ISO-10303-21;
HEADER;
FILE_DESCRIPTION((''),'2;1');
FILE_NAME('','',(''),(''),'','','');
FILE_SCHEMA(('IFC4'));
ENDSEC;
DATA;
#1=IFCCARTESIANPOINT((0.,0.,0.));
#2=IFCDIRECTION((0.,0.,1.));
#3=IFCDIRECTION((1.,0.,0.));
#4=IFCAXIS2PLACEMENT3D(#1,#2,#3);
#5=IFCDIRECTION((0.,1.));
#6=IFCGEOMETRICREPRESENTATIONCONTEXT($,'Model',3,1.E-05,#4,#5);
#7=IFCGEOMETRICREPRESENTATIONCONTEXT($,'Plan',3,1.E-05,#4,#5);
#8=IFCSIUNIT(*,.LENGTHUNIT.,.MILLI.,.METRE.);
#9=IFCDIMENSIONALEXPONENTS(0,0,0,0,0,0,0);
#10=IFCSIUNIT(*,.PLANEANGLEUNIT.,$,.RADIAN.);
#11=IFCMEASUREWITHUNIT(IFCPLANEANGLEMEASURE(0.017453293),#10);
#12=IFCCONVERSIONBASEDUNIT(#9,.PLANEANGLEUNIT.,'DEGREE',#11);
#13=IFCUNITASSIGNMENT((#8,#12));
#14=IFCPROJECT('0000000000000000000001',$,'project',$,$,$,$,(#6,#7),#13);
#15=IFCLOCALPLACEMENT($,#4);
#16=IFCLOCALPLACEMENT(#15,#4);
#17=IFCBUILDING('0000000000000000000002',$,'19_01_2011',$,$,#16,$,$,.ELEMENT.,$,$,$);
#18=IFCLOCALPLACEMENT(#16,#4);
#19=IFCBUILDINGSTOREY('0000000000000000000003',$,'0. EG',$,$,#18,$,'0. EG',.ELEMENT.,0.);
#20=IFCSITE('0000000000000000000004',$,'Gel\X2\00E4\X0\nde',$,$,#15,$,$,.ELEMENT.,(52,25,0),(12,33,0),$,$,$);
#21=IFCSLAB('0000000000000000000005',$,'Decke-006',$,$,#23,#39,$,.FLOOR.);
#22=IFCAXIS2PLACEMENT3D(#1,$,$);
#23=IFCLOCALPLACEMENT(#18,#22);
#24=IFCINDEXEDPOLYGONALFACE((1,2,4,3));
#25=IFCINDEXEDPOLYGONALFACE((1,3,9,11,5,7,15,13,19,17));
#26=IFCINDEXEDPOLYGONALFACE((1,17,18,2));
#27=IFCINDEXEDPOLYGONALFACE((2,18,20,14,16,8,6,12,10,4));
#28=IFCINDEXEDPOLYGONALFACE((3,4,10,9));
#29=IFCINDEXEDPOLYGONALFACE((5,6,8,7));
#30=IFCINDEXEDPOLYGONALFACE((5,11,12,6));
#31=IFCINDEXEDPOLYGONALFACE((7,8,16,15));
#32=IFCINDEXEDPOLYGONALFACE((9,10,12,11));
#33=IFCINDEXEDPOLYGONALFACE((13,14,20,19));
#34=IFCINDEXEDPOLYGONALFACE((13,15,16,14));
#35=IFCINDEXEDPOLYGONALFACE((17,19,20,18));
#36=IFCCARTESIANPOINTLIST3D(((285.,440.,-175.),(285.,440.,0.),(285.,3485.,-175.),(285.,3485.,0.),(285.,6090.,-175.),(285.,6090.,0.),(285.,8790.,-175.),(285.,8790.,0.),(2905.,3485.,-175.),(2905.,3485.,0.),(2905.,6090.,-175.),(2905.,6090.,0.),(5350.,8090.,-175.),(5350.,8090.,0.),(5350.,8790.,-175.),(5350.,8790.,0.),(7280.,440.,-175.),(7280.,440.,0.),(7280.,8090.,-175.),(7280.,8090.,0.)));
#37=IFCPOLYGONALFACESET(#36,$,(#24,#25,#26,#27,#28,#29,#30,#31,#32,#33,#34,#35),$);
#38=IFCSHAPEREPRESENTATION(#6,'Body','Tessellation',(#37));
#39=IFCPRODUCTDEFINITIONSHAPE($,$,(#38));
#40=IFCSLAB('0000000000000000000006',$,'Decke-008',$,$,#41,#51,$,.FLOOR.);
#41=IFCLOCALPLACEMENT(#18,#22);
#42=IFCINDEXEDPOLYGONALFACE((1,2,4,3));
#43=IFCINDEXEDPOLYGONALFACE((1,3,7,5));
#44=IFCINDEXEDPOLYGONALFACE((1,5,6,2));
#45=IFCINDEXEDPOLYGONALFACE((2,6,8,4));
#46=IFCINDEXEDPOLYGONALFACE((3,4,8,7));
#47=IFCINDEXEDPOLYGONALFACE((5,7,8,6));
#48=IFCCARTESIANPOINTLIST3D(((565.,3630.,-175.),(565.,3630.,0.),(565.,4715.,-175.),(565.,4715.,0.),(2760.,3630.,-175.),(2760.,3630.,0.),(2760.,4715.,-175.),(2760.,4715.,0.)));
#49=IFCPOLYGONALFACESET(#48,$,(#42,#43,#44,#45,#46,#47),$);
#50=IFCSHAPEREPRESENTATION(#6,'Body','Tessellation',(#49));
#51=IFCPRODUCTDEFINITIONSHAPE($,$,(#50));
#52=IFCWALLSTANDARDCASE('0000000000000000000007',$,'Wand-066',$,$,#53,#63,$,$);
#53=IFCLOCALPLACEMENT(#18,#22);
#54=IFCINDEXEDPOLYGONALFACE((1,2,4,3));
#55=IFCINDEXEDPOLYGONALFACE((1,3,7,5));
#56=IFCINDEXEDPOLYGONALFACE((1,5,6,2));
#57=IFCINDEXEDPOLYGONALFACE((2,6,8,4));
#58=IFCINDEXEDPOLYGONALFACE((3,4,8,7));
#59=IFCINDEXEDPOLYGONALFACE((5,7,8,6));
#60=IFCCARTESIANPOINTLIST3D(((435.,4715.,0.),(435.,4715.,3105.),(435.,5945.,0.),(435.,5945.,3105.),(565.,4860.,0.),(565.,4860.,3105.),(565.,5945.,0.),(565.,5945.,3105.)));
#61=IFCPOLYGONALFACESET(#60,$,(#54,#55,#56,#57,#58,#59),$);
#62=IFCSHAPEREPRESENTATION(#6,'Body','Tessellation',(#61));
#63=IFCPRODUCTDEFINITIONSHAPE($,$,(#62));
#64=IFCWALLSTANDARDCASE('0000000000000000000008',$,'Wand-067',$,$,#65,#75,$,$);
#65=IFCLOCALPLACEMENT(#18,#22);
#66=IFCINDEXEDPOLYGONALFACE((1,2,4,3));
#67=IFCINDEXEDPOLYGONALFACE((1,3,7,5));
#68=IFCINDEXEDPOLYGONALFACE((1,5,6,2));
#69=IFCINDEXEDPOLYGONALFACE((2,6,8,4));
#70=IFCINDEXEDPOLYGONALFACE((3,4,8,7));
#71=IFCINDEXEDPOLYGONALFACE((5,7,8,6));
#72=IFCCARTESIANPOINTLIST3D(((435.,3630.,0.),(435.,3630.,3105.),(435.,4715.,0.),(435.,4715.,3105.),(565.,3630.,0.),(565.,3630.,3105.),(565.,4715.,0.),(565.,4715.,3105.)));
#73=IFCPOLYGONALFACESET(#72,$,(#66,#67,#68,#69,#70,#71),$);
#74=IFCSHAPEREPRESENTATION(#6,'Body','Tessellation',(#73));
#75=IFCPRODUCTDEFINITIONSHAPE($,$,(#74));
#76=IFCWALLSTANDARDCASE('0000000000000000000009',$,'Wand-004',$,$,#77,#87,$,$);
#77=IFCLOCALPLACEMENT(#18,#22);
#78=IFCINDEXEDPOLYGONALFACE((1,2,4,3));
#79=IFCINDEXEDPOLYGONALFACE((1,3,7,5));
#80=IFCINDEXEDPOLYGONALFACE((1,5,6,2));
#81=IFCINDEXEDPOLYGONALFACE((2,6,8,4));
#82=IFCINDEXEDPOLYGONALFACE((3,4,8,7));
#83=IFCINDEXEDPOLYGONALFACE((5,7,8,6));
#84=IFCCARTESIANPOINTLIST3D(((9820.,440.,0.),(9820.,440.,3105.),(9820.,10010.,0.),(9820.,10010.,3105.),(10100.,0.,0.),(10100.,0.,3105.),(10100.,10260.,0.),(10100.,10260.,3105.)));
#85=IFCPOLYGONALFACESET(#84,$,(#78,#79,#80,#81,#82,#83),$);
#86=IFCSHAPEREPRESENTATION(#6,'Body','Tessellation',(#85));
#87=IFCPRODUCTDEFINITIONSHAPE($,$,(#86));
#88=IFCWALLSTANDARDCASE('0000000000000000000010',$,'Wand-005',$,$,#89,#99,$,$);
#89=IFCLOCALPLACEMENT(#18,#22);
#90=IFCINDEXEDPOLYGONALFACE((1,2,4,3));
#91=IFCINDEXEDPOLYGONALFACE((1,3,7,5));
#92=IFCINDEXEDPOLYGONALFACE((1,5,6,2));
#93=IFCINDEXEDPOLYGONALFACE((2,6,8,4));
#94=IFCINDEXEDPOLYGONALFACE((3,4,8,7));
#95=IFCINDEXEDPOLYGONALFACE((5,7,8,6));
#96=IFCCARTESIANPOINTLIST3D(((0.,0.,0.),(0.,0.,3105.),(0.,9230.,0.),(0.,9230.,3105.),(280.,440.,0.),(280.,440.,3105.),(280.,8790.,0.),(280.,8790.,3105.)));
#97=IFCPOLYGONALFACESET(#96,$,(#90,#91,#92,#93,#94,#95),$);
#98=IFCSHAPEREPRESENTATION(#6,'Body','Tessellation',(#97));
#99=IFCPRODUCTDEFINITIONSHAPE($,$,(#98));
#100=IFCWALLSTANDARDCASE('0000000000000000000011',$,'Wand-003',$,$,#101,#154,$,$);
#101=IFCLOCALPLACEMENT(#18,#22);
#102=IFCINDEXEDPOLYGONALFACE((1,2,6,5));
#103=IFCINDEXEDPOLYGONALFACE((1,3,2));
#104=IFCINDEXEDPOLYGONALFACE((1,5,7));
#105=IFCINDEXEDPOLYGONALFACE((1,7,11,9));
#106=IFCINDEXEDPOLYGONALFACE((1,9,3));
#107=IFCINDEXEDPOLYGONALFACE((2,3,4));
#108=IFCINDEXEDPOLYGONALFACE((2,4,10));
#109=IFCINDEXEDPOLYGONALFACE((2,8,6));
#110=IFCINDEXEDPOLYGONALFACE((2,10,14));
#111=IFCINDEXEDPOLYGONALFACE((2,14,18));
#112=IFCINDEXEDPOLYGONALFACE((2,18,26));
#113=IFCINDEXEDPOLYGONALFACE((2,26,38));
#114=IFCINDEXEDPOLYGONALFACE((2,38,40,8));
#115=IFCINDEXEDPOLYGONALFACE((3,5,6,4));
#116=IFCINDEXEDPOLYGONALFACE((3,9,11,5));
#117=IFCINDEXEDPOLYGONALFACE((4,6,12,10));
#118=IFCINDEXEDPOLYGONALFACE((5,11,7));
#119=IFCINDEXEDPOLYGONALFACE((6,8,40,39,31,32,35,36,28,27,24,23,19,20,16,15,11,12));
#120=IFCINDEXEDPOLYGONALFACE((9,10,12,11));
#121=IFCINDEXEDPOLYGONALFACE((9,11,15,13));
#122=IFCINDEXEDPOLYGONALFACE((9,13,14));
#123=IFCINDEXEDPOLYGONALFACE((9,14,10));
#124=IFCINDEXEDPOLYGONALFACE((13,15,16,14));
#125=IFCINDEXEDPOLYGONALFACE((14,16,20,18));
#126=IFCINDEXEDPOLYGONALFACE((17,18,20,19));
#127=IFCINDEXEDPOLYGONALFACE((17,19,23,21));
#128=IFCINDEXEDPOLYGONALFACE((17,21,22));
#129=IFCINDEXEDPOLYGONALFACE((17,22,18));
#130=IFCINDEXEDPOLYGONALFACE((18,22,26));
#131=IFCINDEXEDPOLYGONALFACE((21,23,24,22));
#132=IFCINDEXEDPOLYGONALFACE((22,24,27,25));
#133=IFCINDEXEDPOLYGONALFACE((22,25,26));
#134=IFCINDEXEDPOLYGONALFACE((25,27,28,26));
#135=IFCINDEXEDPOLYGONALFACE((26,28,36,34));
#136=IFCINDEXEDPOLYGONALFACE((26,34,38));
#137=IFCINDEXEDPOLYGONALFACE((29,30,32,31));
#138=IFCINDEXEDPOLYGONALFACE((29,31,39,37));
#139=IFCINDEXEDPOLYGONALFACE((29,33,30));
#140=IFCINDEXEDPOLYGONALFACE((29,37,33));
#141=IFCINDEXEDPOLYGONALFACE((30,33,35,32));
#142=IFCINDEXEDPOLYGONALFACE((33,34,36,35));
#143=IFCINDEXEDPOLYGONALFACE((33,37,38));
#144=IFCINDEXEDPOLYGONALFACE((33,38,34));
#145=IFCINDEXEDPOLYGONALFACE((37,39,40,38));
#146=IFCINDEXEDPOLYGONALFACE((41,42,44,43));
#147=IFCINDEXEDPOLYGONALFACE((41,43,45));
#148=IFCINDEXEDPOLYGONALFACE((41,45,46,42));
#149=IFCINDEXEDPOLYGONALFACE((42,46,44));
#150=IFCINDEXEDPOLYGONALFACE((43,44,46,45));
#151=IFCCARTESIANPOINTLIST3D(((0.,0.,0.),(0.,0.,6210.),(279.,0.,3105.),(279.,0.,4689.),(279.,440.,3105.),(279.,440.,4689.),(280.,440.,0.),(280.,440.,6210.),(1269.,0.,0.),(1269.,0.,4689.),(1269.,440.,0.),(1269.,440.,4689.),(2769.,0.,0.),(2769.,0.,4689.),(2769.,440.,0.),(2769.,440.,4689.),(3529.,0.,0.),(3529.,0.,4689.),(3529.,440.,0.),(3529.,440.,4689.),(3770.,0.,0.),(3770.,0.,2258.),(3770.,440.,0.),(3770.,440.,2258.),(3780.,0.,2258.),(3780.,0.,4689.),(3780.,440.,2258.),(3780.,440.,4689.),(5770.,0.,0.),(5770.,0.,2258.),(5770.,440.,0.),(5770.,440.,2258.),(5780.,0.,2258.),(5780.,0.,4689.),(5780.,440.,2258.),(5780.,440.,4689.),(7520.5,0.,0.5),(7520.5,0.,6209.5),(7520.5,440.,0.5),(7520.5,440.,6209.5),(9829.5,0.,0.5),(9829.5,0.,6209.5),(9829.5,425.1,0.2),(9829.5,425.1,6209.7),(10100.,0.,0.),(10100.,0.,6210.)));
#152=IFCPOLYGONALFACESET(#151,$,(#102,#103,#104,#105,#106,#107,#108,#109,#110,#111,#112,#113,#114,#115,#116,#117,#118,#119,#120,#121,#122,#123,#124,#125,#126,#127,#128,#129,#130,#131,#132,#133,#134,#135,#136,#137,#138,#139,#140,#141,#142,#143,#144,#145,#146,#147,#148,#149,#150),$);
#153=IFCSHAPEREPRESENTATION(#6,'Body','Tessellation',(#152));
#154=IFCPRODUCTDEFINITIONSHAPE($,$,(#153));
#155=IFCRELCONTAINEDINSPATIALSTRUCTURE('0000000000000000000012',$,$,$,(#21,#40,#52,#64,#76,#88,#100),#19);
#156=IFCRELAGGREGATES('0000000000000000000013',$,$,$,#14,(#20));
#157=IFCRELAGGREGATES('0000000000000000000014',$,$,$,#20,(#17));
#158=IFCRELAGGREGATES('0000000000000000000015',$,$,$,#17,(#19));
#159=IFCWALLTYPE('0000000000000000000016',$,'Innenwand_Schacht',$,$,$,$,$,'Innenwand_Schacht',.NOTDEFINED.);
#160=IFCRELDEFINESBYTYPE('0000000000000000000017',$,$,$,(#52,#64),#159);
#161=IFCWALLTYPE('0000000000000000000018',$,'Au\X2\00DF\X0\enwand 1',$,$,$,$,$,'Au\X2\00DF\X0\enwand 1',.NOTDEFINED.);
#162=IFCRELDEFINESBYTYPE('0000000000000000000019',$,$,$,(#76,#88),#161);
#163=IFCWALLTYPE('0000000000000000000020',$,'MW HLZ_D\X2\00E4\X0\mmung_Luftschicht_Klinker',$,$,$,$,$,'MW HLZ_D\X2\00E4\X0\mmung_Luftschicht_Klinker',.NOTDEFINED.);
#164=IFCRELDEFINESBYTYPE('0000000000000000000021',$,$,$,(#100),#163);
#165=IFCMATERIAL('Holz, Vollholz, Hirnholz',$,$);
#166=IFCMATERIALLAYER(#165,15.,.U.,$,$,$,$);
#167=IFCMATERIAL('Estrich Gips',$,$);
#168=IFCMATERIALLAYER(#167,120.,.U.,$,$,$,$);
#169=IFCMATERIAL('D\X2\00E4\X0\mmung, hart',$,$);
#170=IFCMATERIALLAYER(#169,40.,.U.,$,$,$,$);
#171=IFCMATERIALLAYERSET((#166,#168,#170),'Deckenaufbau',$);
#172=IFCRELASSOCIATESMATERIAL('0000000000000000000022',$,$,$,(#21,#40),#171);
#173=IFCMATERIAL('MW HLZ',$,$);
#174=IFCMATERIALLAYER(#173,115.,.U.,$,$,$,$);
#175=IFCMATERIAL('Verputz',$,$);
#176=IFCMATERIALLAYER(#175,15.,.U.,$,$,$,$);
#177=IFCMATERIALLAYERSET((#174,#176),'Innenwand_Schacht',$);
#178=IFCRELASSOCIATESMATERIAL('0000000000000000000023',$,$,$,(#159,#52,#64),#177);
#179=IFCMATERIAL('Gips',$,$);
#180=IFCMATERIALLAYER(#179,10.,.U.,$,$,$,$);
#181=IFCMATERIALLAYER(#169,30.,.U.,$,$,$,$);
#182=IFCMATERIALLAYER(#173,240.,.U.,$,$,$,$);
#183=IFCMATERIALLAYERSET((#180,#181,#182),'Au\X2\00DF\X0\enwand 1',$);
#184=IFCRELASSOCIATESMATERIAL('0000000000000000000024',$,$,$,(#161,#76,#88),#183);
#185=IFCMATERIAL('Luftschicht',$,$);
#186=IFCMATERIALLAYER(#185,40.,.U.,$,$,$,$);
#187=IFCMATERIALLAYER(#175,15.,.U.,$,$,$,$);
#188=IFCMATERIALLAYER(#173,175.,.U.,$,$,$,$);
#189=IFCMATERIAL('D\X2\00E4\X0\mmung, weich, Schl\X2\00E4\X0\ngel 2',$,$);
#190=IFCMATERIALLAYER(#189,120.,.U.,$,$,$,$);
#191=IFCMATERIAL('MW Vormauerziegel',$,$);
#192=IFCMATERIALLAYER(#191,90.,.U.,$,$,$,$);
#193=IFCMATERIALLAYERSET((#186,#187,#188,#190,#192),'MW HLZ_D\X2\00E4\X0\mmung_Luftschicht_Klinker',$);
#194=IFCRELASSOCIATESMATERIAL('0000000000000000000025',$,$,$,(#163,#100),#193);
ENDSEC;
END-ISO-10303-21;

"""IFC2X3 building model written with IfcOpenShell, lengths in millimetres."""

from ifc_helpers import new_model, entity, si_unit, converted_unit, direction, frame, frame_2d, origin_with_axes, place, context, project, spatial, polyline, rectangle, outline, extrude, material, layer, layer_set, layer_usage, type_object, element, save


model = new_model("IFC2X3")

# Units and contexts
model_context = context("Model", 3, precision=1e-05, world=origin_with_axes(), true_north=direction((0.0, 1.0)))
plan_context = context("Plan", 3, precision=1e-05, world=origin_with_axes(), true_north=direction((0.0, 1.0)))
ifc_project = project(units=[si_unit("LENGTHUNIT", "METRE", prefix="MILLI"), converted_unit("PLANEANGLEUNIT", "DEGREE", entity("IfcPlaneAngleMeasure", 0.017453293), si_unit("PLANEANGLEUNIT", "RADIAN"), dimensions=[0, 0, 0, 0, 0, 0, 0])], contexts=[model_context, plan_context])

# Site, building, storey
site_placement = place(None, origin_with_axes())
site = spatial("IfcSite", under=ifc_project, at=site_placement, Name="Gelände", CompositionType="ELEMENT", RefLatitude=(52, 25, 0), RefLongitude=(12, 33, 0))
building_placement = place(site_placement, origin_with_axes())
building = spatial("IfcBuilding", under=site, at=building_placement, Name="19_01_2011", CompositionType="ELEMENT")
storey_placement = place(building_placement, origin_with_axes())
storey = spatial("IfcBuildingStorey", under=building, at=storey_placement, Name="0. EG", LongName="0. EG", CompositionType="ELEMENT", Elevation=0.0)

# Slabs
ifc_material_1 = material(Name="Holz, Vollholz, Hirnholz")
ifc_layer_1 = layer(ifc_material_1, 15.0, ventilated="UNKNOWN")
ifc_material_2 = material(Name="Estrich Gips")
ifc_layer_2 = layer(ifc_material_2, 120.0, ventilated="UNKNOWN")
ifc_material_3 = material(Name="Dämmung, hart")
ifc_layer_3 = layer(ifc_material_3, 40.0, ventilated="UNKNOWN")
ifc_layer_set_1 = layer_set([ifc_layer_1, ifc_layer_2, ifc_layer_3], Name="Deckenaufbau")
ifc_layer_usage_1 = layer_usage(ifc_layer_set_1, "AXIS3", "NEGATIVE", 175.0)
slab_1_placement = place(storey_placement, frame((285.0, 440.0, -175.0), z_axis=(0.0, 0.0, 1.0), x_axis=(1.0, 0.0, 0.0)))
element("IfcSlab", 1, at=slab_1_placement, inside=storey, material=ifc_layer_usage_1, Name="Decke-006", PredefinedType="FLOOR", context=model_context, shape_type="SweptSolid", body=[
    extrude(outline(polyline([(0.0, 0.0), (6995.0, 0.0), (6995.0, 7650.0), (5065.0, 7650.0), (5065.0, 8350.0), (0.0, 8350.0), (0.0, 5650.0), (2620.0, 5650.0), (2620.0, 3045.0), (0.0, 3045.0), (0.0, 0.0)])), origin_with_axes(), (0.0, 0.0, 1.0), 175.0),
])
ifc_layer_usage_2 = layer_usage(ifc_layer_set_1, "AXIS3", "NEGATIVE", 175.0)
slab_2_placement = place(storey_placement, frame((565.0, 4715.0, -175.0), z_axis=(0.0, 0.0, 1.0), x_axis=(1.0, 0.0, 0.0)))
element("IfcSlab", 2, at=slab_2_placement, inside=storey, material=ifc_layer_usage_2, Name="Decke-008", PredefinedType="FLOOR", context=model_context, shape_type="SweptSolid", body=[
    extrude(outline(polyline([(0.0, 0.0), (2195.0, 0.0), (2195.0, -1085.0), (0.0, -1085.0), (0.0, 0.0)])), origin_with_axes(), (0.0, 0.0, 1.0), 175.0),
])

# Walls
ifc_material_4 = material(Name="MW HLZ")
ifc_layer_4 = layer(ifc_material_4, 115.0, ventilated="UNKNOWN")
ifc_material_5 = material(Name="Verputz")
ifc_layer_5 = layer(ifc_material_5, 15.0, ventilated="UNKNOWN")
ifc_layer_set_2 = layer_set([ifc_layer_4, ifc_layer_5], Name="Innenwand_Schacht")
ifc_layer_usage_3 = layer_usage(ifc_layer_set_2, "AXIS2", "NEGATIVE", 0.0)
wall_type_1 = type_object("IfcWallType", Name="Innenwand_Schacht", ElementType="Innenwand_Schacht", PredefinedType="NOTDEFINED", material=ifc_layer_set_2)
wall_1_placement = place(storey_placement, frame((435.0, 4715.0, 0.0), z_axis=(0.0, 0.0, 1.0), x_axis=(0.0, 1.0, 0.0)))
element("IfcWallStandardCase", 3, at=wall_1_placement, inside=storey, type_object=wall_type_1, material=ifc_layer_usage_3, Name="Wand-066", context=model_context, shape_type="SweptSolid", body=[
    extrude(outline(polyline([(145.0, -130.0), (1230.0, -130.0), (1230.0, 0.0), (0.0, 0.0), (145.0, -130.0)])), origin_with_axes(), (0.0, 0.0, 1.0), 3105.0),
])
ifc_layer_usage_4 = layer_usage(ifc_layer_set_2, "AXIS2", "POSITIVE", 0.0)
wall_2_placement = place(storey_placement, frame((435.0, 4715.0, 0.0), z_axis=(0.0, 0.0, 1.0), x_axis=(0.0, -1.0, 0.0)))
element("IfcWallStandardCase", 4, at=wall_2_placement, inside=storey, type_object=wall_type_1, material=ifc_layer_usage_4, Name="Wand-067", context=model_context, shape_type="SweptSolid", body=[
    extrude(outline(polyline([(0.0, 0.0), (1085.0, 0.0), (1085.0, 130.0), (0.0, 130.0), (0.0, 0.0)])), origin_with_axes(), (0.0, 0.0, 1.0), 3105.0),
])
ifc_material_6 = material(Name="Gips")
ifc_layer_6 = layer(ifc_material_6, 10.0, ventilated="UNKNOWN")
ifc_layer_7 = layer(ifc_material_3, 30.0, ventilated="UNKNOWN")
ifc_layer_8 = layer(ifc_material_4, 240.0, ventilated="UNKNOWN")
ifc_layer_set_3 = layer_set([ifc_layer_6, ifc_layer_7, ifc_layer_8], Name="Außenwand 1")
ifc_layer_usage_5 = layer_usage(ifc_layer_set_3, "AXIS2", "POSITIVE", 0.0)
wall_type_2 = type_object("IfcWallType", Name="Außenwand 1", ElementType="Außenwand 1", PredefinedType="NOTDEFINED", material=ifc_layer_set_3)
wall_3_placement = place(storey_placement, frame((10100.0, 0.0, 0.0), z_axis=(0.0, 0.0, 1.0), x_axis=(0.0, 1.0, 0.0)))
element("IfcWallStandardCase", 5, at=wall_3_placement, inside=storey, type_object=wall_type_2, material=ifc_layer_usage_5, Name="Wand-004", context=model_context, shape_type="SweptSolid", body=[
    extrude(outline(polyline([(0.0, 0.0), (10260.0, 0.0), (10010.0, 280.0), (440.0, 280.0), (0.0, 0.0)])), origin_with_axes(), (0.0, 0.0, 1.0), 3105.0),
])
ifc_layer_usage_6 = layer_usage(ifc_layer_set_3, "AXIS2", "NEGATIVE", 0.0)
wall_4_placement = place(storey_placement, frame((0.0, 0.0, 0.0), z_axis=(0.0, 0.0, 1.0), x_axis=(0.0, 1.0, 0.0)))
element("IfcWallStandardCase", 6, at=wall_4_placement, inside=storey, type_object=wall_type_2, material=ifc_layer_usage_6, Name="Wand-005", context=model_context, shape_type="SweptSolid", body=[
    extrude(outline(polyline([(440.0, -280.0), (8790.0, -280.0), (9230.0, 0.0), (0.0, 0.0), (440.0, -280.0)])), origin_with_axes(), (0.0, 0.0, 1.0), 3105.0),
])

# Wall, openings
ifc_material_7 = material(Name="Luftschicht")
ifc_layer_9 = layer(ifc_material_7, 40.0, ventilated="UNKNOWN")
ifc_layer_10 = layer(ifc_material_5, 15.0, ventilated="UNKNOWN")
ifc_layer_11 = layer(ifc_material_4, 175.0, ventilated="UNKNOWN")
ifc_material_8 = material(Name="Dämmung, weich, Schlängel 2")
ifc_layer_12 = layer(ifc_material_8, 120.0, ventilated="UNKNOWN")
ifc_material_9 = material(Name="MW Vormauerziegel")
ifc_layer_13 = layer(ifc_material_9, 90.0, ventilated="UNKNOWN")
ifc_layer_set_4 = layer_set([ifc_layer_9, ifc_layer_10, ifc_layer_11, ifc_layer_12, ifc_layer_13], Name="MW HLZ_Dämmung_Luftschicht_Klinker")
ifc_layer_usage_7 = layer_usage(ifc_layer_set_4, "AXIS2", "POSITIVE", 0.0)
wall_type_3 = type_object("IfcWallType", Name="MW HLZ_Dämmung_Luftschicht_Klinker", ElementType="MW HLZ_Dämmung_Luftschicht_Klinker", PredefinedType="NOTDEFINED", material=ifc_layer_set_4)
wall_5_placement = place(storey_placement, origin_with_axes())
wall_5 = element("IfcWallStandardCase", 7, at=wall_5_placement, inside=storey, type_object=wall_type_3, material=ifc_layer_usage_7, Name="Wand-003", context=model_context, shape_type="SweptSolid", body=[
    extrude(outline(polyline([(0.0, 0.0), (10100.0, 0.0), (9820.0, 440.0), (280.0, 440.0), (0.0, 0.0)])), origin_with_axes(), (0.0, 0.0, 1.0), 6210.0),
])
opening_1_placement = place(wall_5_placement, frame((3149.0, 0.0, 0.0), z_axis=(0.0, 0.0, 1.0), x_axis=(1.0, 0.0, 0.0)))
element("IfcOpeningElement", 8, at=opening_1_placement, cuts=wall_5, ObjectType="Opening", context=model_context, shape_type="SweptSolid", body=[
    extrude(rectangle(XDim=760.0, YDim=4689.0, at=frame_2d((0.0, 2344.5), x_axis=(-1.0, 0.0))), frame((0.0, 0.0, 0.0), z_axis=(0.0, 1.0, 0.0), x_axis=(-1.0, 0.0, 0.0)), (0.0, 0.0, 1.0), 440.0),
])
opening_2_placement = place(wall_5_placement, frame((9180.0, 0.0, 0.0), z_axis=(0.0, 0.0, 1.0), x_axis=(1.0, 0.0, 0.0)))
element("IfcOpeningElement", 9, at=opening_2_placement, cuts=wall_5, ObjectType="Opening", context=model_context, shape_type="SweptSolid", body=[
    extrude(rectangle(XDim=1299.0, YDim=3104.0, at=frame_2d((0.0, 1552.5), x_axis=(1.0, 0.0))), frame((0.0, 0.0, 0.0), z_axis=(0.0, 1.0, 0.0), x_axis=(-1.0, 0.0, 0.0)), (0.0, 0.0, 1.0), 440.0),
])
opening_3_placement = place(wall_5_placement, frame((8025.0, 0.0, 0.0), z_axis=(0.0, 0.0, 1.0), x_axis=(1.0, 0.0, 0.0)))
element("IfcOpeningElement", 10, at=opening_3_placement, cuts=wall_5, ObjectType="Opening", context=model_context, shape_type="SweptSolid", body=[
    extrude(rectangle(XDim=1009.0, YDim=3104.0, at=frame_2d((0.0, 1552.5), x_axis=(1.0, 0.0))), frame((0.0, 0.0, 0.0), z_axis=(0.0, 1.0, 0.0), x_axis=(-1.0, 0.0, 0.0)), (0.0, 0.0, 1.0), 440.0),
])
opening_4_placement = place(wall_5_placement, frame((8675.0, 0.0, 3105.0), z_axis=(0.0, 0.0, 1.0), x_axis=(1.0, 0.0, 0.0)))
element("IfcOpeningElement", 11, at=opening_4_placement, cuts=wall_5, ObjectType="Opening", context=model_context, shape_type="SweptSolid", body=[
    extrude(rectangle(XDim=2309.0, YDim=3104.0, at=frame_2d((0.0, 1552.5), x_axis=(1.0, 0.0))), frame((0.0, 0.0, 0.0), z_axis=(0.0, 1.0, 0.0), x_axis=(-1.0, 0.0, 0.0)), (0.0, 0.0, 1.0), 440.0),
])
opening_5_placement = place(wall_5_placement, frame((4770.0, 0.0, 0.0), z_axis=(0.0, 0.0, 1.0), x_axis=(1.0, 0.0, 0.0)))
element("IfcOpeningElement", 12, at=opening_5_placement, cuts=wall_5, ObjectType="Opening", context=model_context, shape_type="SweptSolid", body=[
    extrude(outline(polyline([(1000.0, 0.0), (1000.0, 2258.0), (990.0, 2258.0), (-1000.0, 2258.0), (-1000.0, 0.0), (1000.0, 0.0)])), frame((0.0, 0.0, 0.0), z_axis=(0.0, 1.0, 0.0), x_axis=(-1.0, 0.0, 0.0)), (0.0, 0.0, 1.0), 440.0),
])
opening_6_placement = place(wall_5_placement, frame((774.0, 0.0, 0.0), z_axis=(0.0, 0.0, 1.0), x_axis=(1.0, 0.0, 0.0)))
element("IfcOpeningElement", 13, at=opening_6_placement, cuts=wall_5, ObjectType="Opening", context=model_context, shape_type="SweptSolid", body=[
    extrude(outline(polyline([(495.0, 4689.0), (-495.0, 4689.0), (-495.0, 0.0), (495.0, 3105.0), (495.0, 4689.0)])), frame((0.0, 0.0, 0.0), z_axis=(0.0, 1.0, 0.0), x_axis=(-1.0, 0.0, 0.0)), (0.0, 0.0, 1.0), 440.0),
])
opening_7_placement = place(wall_5_placement, frame((4780.0, 0.0, 2258.0), z_axis=(0.0, 0.0, 1.0), x_axis=(1.0, 0.0, 0.0)))
element("IfcOpeningElement", 14, at=opening_7_placement, cuts=wall_5, ObjectType="Opening", context=model_context, shape_type="SweptSolid", body=[
    extrude(outline(polyline([(1000.0, 0.0), (1000.0, 2431.0), (-1000.0, 2431.0), (-1000.0, 0.0), (-990.0, 0.0), (1000.0, 0.0)])), frame((0.0, 0.0, 0.0), z_axis=(0.0, 1.0, 0.0), x_axis=(-1.0, 0.0, 0.0)), (0.0, 0.0, 1.0), 440.0),
])

save(model, "model.ifc")
